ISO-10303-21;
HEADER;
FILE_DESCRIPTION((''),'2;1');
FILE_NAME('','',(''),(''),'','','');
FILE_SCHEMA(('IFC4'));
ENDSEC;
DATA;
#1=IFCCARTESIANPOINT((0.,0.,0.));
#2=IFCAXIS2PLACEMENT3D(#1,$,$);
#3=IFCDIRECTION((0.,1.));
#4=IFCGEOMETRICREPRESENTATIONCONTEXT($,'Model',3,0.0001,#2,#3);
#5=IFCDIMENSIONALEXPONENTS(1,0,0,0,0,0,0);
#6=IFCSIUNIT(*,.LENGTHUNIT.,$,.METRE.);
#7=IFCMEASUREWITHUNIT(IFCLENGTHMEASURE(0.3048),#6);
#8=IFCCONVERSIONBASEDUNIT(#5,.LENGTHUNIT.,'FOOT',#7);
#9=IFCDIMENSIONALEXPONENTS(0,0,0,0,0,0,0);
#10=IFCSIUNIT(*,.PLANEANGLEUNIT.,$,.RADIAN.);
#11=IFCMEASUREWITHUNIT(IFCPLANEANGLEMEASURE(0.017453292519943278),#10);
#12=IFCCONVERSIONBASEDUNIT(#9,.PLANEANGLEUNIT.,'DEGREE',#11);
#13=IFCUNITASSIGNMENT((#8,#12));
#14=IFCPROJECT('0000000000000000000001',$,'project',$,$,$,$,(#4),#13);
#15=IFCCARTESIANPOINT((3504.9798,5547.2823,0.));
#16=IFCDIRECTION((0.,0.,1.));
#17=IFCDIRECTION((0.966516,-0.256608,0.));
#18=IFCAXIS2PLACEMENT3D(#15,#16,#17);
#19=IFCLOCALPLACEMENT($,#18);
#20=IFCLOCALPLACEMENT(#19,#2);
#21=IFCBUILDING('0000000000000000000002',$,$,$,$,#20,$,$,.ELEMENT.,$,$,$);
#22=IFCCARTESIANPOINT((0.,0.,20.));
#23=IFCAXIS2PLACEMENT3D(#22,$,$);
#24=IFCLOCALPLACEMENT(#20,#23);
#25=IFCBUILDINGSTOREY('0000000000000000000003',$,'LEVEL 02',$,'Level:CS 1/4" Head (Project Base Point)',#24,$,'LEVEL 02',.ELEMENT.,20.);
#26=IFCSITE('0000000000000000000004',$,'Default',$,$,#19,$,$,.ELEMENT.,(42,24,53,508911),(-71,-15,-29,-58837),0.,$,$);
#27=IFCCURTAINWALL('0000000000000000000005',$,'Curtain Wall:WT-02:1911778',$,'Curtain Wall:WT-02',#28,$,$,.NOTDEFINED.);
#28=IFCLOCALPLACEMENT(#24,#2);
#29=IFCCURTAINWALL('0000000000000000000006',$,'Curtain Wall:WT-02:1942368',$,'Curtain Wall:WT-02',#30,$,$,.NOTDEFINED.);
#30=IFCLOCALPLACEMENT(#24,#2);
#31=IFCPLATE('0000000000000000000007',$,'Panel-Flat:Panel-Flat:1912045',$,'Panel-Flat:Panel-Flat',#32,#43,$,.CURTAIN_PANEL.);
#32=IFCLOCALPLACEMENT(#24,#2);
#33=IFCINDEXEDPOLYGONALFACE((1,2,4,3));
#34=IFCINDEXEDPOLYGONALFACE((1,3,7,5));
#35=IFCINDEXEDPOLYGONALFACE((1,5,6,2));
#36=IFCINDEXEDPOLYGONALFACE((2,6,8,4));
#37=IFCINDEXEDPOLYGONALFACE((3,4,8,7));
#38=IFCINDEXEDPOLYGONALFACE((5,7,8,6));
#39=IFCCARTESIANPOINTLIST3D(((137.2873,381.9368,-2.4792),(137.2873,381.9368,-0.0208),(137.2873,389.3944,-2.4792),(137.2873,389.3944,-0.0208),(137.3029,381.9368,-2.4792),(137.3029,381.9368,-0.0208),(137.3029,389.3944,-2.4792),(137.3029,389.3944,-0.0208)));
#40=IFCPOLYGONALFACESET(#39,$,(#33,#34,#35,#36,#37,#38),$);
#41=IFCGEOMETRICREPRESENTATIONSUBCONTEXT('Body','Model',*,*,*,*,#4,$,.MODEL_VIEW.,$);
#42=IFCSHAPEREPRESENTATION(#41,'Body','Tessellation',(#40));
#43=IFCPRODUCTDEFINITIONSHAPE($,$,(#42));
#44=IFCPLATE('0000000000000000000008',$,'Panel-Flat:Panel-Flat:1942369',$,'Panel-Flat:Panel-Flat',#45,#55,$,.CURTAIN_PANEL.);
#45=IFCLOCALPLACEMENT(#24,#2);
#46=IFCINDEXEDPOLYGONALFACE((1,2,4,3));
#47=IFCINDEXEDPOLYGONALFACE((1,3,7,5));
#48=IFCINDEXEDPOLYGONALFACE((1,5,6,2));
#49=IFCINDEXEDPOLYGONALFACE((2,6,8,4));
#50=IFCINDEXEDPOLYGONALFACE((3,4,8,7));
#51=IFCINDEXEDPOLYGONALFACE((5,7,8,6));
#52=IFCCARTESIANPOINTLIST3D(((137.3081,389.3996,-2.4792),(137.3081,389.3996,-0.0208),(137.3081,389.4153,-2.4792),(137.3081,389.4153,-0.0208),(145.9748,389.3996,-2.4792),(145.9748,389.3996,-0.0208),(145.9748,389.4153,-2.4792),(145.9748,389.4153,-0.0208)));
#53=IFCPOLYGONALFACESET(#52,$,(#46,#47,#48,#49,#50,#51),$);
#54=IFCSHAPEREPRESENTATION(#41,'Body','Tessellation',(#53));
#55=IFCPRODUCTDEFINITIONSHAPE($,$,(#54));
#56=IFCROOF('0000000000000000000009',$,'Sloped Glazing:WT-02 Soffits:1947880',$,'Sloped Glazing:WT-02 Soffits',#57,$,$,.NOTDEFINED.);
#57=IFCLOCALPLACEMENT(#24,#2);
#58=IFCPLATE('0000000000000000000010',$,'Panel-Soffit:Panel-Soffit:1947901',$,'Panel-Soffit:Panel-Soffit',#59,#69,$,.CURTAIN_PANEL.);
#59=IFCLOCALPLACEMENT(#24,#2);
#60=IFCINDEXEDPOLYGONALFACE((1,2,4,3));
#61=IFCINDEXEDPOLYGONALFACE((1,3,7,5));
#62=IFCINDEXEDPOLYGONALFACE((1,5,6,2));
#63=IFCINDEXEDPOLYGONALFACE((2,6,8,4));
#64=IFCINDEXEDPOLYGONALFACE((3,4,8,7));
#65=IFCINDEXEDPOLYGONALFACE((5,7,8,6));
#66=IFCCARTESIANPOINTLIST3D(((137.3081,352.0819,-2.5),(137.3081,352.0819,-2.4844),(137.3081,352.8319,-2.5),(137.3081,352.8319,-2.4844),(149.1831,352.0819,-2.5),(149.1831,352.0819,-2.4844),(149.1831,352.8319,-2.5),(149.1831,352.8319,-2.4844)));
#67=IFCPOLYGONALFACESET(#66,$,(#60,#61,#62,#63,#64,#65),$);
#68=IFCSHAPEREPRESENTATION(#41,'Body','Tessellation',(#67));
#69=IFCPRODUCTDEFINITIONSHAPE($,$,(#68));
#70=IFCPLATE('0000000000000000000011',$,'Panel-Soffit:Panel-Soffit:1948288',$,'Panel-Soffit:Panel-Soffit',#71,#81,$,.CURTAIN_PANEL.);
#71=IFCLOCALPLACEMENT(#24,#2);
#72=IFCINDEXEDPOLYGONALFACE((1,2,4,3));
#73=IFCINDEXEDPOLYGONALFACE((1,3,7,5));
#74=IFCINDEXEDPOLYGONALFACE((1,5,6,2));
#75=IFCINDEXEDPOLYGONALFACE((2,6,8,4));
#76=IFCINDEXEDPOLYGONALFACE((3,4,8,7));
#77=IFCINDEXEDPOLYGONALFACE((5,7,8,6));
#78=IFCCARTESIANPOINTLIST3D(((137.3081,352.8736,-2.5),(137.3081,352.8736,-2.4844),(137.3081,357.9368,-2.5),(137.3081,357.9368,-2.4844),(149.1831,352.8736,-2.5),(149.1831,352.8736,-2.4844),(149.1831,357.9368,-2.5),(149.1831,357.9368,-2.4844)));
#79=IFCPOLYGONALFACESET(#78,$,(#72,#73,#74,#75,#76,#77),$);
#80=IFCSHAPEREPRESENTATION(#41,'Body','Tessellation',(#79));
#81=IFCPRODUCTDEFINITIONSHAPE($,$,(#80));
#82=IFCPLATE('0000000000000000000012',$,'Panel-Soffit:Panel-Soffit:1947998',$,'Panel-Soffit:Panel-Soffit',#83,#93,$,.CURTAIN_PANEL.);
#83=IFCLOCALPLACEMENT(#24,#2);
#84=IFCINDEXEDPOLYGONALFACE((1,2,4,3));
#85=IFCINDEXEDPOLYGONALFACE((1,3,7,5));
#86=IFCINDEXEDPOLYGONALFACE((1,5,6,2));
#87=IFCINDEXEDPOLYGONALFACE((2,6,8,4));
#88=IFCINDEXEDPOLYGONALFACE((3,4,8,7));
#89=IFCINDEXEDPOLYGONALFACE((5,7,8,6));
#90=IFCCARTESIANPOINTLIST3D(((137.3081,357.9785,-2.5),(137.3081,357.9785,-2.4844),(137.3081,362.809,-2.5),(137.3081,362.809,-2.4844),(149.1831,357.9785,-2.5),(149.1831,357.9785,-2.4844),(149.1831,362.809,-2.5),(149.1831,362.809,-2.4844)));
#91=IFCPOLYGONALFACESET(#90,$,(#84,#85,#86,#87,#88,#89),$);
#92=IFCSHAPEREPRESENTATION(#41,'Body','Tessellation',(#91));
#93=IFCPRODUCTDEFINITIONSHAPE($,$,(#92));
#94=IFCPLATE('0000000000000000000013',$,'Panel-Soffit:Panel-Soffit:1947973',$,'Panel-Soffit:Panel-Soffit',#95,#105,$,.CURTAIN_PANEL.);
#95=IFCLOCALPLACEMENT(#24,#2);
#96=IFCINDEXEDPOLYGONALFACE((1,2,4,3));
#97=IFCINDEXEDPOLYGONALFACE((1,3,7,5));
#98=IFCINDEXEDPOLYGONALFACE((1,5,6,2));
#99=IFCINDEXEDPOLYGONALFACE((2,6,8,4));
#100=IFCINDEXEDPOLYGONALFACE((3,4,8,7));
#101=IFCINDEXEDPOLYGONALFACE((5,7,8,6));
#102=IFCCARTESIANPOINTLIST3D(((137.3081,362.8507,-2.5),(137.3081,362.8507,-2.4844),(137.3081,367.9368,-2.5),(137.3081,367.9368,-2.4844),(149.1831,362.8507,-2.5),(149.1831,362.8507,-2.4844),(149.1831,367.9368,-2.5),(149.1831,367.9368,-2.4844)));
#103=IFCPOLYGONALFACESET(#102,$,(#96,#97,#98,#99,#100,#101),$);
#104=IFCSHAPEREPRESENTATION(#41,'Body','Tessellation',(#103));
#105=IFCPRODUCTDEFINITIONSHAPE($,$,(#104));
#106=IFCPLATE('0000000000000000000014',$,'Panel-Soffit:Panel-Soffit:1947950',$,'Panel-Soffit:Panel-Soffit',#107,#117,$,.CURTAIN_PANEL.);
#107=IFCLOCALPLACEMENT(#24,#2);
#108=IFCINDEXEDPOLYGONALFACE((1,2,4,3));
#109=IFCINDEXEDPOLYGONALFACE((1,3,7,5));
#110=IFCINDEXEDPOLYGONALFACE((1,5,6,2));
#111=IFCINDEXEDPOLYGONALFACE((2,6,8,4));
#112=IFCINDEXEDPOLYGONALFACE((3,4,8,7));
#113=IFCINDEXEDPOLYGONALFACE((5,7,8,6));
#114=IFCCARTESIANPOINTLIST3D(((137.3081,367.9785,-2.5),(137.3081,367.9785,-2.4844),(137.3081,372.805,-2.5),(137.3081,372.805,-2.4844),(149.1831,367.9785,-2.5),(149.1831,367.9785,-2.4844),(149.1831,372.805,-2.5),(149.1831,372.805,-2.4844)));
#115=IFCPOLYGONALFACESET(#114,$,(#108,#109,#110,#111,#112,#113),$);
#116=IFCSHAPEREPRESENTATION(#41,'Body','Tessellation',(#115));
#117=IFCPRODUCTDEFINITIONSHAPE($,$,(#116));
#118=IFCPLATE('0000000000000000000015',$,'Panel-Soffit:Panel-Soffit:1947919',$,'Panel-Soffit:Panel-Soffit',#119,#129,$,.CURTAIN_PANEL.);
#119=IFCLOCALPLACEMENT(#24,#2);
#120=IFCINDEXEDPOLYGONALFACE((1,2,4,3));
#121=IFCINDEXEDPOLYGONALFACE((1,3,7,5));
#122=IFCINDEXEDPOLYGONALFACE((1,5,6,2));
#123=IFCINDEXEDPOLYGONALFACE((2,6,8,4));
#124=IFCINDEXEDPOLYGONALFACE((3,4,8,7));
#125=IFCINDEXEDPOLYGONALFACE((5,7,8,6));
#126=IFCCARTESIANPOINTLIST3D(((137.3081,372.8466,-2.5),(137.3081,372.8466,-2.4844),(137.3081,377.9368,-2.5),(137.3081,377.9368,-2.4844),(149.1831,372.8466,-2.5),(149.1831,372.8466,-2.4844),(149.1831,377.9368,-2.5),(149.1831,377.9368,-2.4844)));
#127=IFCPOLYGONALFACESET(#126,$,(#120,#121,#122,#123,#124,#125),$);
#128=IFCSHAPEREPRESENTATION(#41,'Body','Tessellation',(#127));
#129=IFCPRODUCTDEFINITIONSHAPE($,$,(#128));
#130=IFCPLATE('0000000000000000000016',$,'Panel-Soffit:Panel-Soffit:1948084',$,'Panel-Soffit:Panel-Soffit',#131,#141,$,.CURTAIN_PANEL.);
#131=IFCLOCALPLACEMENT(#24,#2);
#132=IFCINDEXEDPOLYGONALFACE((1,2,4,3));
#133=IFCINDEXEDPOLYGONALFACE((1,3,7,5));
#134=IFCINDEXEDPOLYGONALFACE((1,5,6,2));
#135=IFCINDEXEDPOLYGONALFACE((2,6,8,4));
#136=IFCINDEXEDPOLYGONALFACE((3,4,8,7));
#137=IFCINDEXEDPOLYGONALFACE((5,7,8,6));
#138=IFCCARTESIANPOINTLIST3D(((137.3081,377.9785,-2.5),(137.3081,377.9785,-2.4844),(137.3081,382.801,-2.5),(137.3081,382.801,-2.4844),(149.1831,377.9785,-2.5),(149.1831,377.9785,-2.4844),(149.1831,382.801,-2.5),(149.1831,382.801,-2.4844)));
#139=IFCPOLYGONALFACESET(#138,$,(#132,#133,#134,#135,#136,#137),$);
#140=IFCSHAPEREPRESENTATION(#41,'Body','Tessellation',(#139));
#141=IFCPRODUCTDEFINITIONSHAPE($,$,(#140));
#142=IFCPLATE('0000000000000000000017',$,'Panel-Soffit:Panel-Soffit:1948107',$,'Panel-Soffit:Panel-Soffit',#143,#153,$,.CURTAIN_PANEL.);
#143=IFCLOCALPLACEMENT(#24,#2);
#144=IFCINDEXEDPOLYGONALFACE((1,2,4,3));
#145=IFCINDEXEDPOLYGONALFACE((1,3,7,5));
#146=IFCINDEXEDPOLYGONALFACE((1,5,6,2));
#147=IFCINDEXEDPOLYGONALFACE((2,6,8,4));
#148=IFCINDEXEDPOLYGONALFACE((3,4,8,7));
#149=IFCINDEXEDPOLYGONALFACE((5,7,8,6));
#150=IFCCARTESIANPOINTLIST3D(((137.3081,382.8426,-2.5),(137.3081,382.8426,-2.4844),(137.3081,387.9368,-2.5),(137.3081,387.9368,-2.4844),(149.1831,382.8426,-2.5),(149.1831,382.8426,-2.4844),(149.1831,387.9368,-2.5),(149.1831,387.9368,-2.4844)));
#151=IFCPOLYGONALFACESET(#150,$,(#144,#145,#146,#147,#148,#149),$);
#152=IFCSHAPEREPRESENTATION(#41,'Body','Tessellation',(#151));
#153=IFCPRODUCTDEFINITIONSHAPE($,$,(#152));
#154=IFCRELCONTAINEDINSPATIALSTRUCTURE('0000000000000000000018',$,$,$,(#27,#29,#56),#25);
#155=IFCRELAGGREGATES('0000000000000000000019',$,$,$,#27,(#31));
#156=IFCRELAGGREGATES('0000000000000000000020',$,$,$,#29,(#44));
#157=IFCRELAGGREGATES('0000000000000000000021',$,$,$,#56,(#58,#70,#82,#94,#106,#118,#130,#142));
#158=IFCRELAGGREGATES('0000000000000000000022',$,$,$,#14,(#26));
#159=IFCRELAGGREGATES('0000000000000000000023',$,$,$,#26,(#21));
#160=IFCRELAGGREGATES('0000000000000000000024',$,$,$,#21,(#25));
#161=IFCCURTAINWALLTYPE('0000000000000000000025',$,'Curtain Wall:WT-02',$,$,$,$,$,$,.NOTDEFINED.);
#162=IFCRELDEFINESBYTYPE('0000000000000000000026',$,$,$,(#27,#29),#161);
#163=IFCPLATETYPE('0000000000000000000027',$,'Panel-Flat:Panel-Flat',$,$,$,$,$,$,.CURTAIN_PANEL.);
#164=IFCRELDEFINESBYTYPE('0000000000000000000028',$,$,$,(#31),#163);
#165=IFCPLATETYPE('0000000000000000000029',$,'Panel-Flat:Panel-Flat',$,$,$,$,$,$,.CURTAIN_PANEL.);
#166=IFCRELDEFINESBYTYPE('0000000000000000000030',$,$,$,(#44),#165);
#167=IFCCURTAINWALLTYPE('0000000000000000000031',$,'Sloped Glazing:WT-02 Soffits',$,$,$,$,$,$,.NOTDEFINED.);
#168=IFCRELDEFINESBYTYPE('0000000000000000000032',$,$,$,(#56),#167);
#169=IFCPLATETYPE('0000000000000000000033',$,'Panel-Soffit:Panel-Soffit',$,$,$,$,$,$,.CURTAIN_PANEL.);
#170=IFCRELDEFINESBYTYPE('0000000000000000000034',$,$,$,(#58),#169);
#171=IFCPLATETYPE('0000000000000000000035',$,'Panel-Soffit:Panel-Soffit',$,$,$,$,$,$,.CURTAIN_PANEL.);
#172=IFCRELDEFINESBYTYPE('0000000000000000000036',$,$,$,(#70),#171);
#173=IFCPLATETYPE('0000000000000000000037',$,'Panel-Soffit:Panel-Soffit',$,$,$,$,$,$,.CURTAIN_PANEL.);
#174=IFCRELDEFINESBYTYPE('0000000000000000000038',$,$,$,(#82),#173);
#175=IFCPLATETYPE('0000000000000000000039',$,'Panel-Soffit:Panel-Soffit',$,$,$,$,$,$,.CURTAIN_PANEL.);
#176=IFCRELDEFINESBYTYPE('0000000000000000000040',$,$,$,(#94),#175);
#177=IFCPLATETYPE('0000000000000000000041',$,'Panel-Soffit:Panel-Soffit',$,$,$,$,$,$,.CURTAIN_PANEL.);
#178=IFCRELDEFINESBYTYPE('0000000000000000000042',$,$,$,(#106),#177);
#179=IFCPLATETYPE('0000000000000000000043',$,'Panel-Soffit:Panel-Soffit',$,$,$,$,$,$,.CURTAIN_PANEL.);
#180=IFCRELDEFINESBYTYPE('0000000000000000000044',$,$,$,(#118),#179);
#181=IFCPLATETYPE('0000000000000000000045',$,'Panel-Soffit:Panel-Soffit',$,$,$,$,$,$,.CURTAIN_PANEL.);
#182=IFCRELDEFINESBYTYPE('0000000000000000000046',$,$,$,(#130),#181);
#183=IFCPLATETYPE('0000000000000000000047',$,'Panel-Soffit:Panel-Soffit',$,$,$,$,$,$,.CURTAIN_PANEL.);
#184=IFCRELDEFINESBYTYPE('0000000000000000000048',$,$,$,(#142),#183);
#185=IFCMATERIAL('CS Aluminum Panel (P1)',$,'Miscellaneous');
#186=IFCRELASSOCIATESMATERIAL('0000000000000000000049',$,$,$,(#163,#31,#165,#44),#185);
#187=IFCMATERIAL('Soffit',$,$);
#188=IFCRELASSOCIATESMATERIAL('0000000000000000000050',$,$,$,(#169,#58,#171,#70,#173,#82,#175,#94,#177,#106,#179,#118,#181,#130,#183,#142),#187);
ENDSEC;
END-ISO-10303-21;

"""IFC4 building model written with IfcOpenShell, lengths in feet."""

from ifc_helpers import new_model, entity, si_unit, converted_unit, direction, frame, origin, place, context, subcontext, project, spatial, indexed_curve, outline, extrude, source, transform, mapped, material, type_object, type_shapes, element, aggregate, save


model = new_model("IFC4")

# Units and contexts
model_context = context("Model", 3, precision=0.0001, world=origin(), true_north=direction((0.0, 1.0)))
body_context = subcontext(model_context, "Body", "Model", "MODEL_VIEW")
ifc_project = project(units=[converted_unit("LENGTHUNIT", "FOOT", entity("IfcLengthMeasure", 0.3048), si_unit("LENGTHUNIT", "METRE"), dimensions=[1, 0, 0, 0, 0, 0, 0]), converted_unit("PLANEANGLEUNIT", "DEGREE", entity("IfcPlaneAngleMeasure", 0.017453292519943278), si_unit("PLANEANGLEUNIT", "RADIAN"), dimensions=[0, 0, 0, 0, 0, 0, 0])], contexts=[model_context])

# Site, building, storey
site_placement = place(None, frame((3504.9798, 5547.2823, 0.0), z_axis=(0.0, 0.0, 1.0), x_axis=(0.966516, -0.256608, 0.0)))
site = spatial("IfcSite", under=ifc_project, at=site_placement, Name="Default", CompositionType="ELEMENT", RefLatitude=(42, 24, 53, 508911), RefLongitude=(-71, -15, -29, -58837), RefElevation=0.0)
building_placement = place(site_placement, origin())
building = spatial("IfcBuilding", under=site, at=building_placement, CompositionType="ELEMENT")
storey_placement = place(building_placement, frame((0.0, 0.0, 20.0)))
storey = spatial("IfcBuildingStorey", under=building, at=storey_placement, Name="LEVEL 02", ObjectType="Level:CS 1/4\" Head (Project Base Point)", LongName="LEVEL 02", CompositionType="ELEMENT", Elevation=20.0)

# Curtain walls
curtain_wall_type_1 = type_object("IfcCurtainWallType", Name="Curtain Wall:WT-02", PredefinedType="NOTDEFINED")
curtain_wall_1_placement = place(storey_placement, frame((0.0, 0.0, -20.0)))
curtain_wall_1 = element("IfcCurtainWall", 1, at=curtain_wall_1_placement, inside=storey, type_object=curtain_wall_type_1, Name="Curtain Wall:WT-02:1911778", ObjectType="Curtain Wall:WT-02", PredefinedType="NOTDEFINED")
ifc_material_1 = material(Name="CS Aluminum Panel (P1)", Category="Miscellaneous")
curtain_wall_2_placement = place(storey_placement, frame((0.0, 0.0, -20.0)))
curtain_wall_2 = element("IfcCurtainWall", 2, at=curtain_wall_2_placement, inside=storey, type_object=curtain_wall_type_1, Name="Curtain Wall:WT-02:1942368", ObjectType="Curtain Wall:WT-02", PredefinedType="NOTDEFINED")

# Plates
plate_type_1 = type_object("IfcPlateType", Name="Panel-Flat:Panel-Flat", PredefinedType="CURTAIN_PANEL", material=ifc_material_1)
shared_shape_1 = source(origin(), body_context, "Body", "SweptSolid", [
    extrude(outline(indexed_curve([(-0.0078, -3.7288), (0.0078, -3.7288), (0.0078, 3.7288), (-0.0078, 3.7288), (-0.0078, -3.7288)], self_intersect=False)), frame((3.7288, 0.0078, 0.0), z_axis=(0.0, 0.0, 1.0), x_axis=(0.0, -1.0, 0.0)), (0.0, 0.0, 1.0), 2.4583),
])
type_shapes(plate_type_1, [shared_shape_1])
plate_1_placement = place(curtain_wall_1_placement, frame((137.3029, 381.9368, 17.5208), z_axis=(0.0, 0.0, 1.0), x_axis=(0.0, 1.0, 0.0)))
plate_1 = element("IfcPlate", 3, at=plate_1_placement, type_object=plate_type_1, material=ifc_material_1, Name="Panel-Flat:Panel-Flat:1912045", ObjectType="Panel-Flat:Panel-Flat", PredefinedType="CURTAIN_PANEL", context=body_context, shape_type="MappedRepresentation", body=[
    mapped(shared_shape_1, transform((0.0, 0.0, 0.0), scale=1.0)),
])
aggregate(curtain_wall_1, [plate_1])
plate_type_2 = type_object("IfcPlateType", Name="Panel-Flat:Panel-Flat", PredefinedType="CURTAIN_PANEL", material=ifc_material_1)
shared_shape_2 = source(origin(), body_context, "Body", "SweptSolid", [
    extrude(outline(indexed_curve([(-0.0078, -4.3333), (0.0078, -4.3333), (0.0078, 4.3333), (-0.0078, 4.3333), (-0.0078, -4.3333)], self_intersect=False)), frame((4.3333, 0.0078, 0.0), z_axis=(0.0, 0.0, 1.0), x_axis=(0.0, -1.0, 0.0)), (0.0, 0.0, 1.0), 2.4583),
])
type_shapes(plate_type_2, [shared_shape_2])
plate_2_placement = place(curtain_wall_2_placement, frame((137.3081, 389.3996, 17.5208)))
plate_2 = element("IfcPlate", 4, at=plate_2_placement, type_object=plate_type_2, material=ifc_material_1, Name="Panel-Flat:Panel-Flat:1942369", ObjectType="Panel-Flat:Panel-Flat", PredefinedType="CURTAIN_PANEL", context=body_context, shape_type="MappedRepresentation", body=[
    mapped(shared_shape_2, transform((0.0, 0.0, 0.0), scale=1.0)),
])
aggregate(curtain_wall_2, [plate_2])

# Roof, plates
curtain_wall_type_2 = type_object("IfcCurtainWallType", Name="Sloped Glazing:WT-02 Soffits", PredefinedType="NOTDEFINED")
roof_1_placement = place(storey_placement, frame((0.0, 0.0, -20.0)))
roof_1 = element("IfcRoof", 5, at=roof_1_placement, inside=storey, type_object=curtain_wall_type_2, Name="Sloped Glazing:WT-02 Soffits:1947880", ObjectType="Sloped Glazing:WT-02 Soffits", PredefinedType="NOTDEFINED")
ifc_material_2 = material(Name="Soffit")
plate_type_3 = type_object("IfcPlateType", Name="Panel-Soffit:Panel-Soffit", PredefinedType="CURTAIN_PANEL", material=ifc_material_2)
shared_shape_3 = source(origin(), body_context, "Body", "SweptSolid", [
    extrude(outline(indexed_curve([(-0.0078, -5.9375), (0.0078, -5.9375), (0.0078, 5.9375), (-0.0078, 5.9375), (-0.0078, -5.9375)], self_intersect=False)), frame((5.9375, 0.0078, 0.0), z_axis=(0.0, 0.0, 1.0), x_axis=(0.0, -1.0, 0.0)), (0.0, 0.0, 1.0), 0.75),
])
type_shapes(plate_type_3, [shared_shape_3])
plate_3_placement = place(roof_1_placement, frame((137.3081, 352.0819, 17.5156), z_axis=(0.0, 1.0, 0.0), x_axis=(1.0, 0.0, 0.0)))
plate_3 = element("IfcPlate", 6, at=plate_3_placement, type_object=plate_type_3, material=ifc_material_2, Name="Panel-Soffit:Panel-Soffit:1947901", ObjectType="Panel-Soffit:Panel-Soffit", PredefinedType="CURTAIN_PANEL", context=body_context, shape_type="MappedRepresentation", body=[
    mapped(shared_shape_3, transform((0.0, 0.0, 0.0), scale=1.0)),
])
plate_type_4 = type_object("IfcPlateType", Name="Panel-Soffit:Panel-Soffit", PredefinedType="CURTAIN_PANEL", material=ifc_material_2)
shared_shape_4 = source(origin(), body_context, "Body", "SweptSolid", [
    extrude(outline(indexed_curve([(-0.0078, -5.9375), (0.0078, -5.9375), (0.0078, 5.9375), (-0.0078, 5.9375), (-0.0078, -5.9375)], self_intersect=False)), frame((5.9375, 0.0078, 0.0), z_axis=(0.0, 0.0, 1.0), x_axis=(0.0, -1.0, 0.0)), (0.0, 0.0, 1.0), 5.0633),
])
type_shapes(plate_type_4, [shared_shape_4])
plate_4_placement = place(roof_1_placement, frame((137.3081, 352.8736, 17.5156), z_axis=(0.0, 1.0, 0.0), x_axis=(1.0, 0.0, 0.0)))
plate_4 = element("IfcPlate", 7, at=plate_4_placement, type_object=plate_type_4, material=ifc_material_2, Name="Panel-Soffit:Panel-Soffit:1948288", ObjectType="Panel-Soffit:Panel-Soffit", PredefinedType="CURTAIN_PANEL", context=body_context, shape_type="MappedRepresentation", body=[
    mapped(shared_shape_4, transform((0.0, 0.0, 0.0), scale=1.0)),
])
plate_type_5 = type_object("IfcPlateType", Name="Panel-Soffit:Panel-Soffit", PredefinedType="CURTAIN_PANEL", material=ifc_material_2)
shared_shape_5 = source(origin(), body_context, "Body", "SweptSolid", [
    extrude(outline(indexed_curve([(-0.0078, -5.9375), (0.0078, -5.9375), (0.0078, 5.9375), (-0.0078, 5.9375), (-0.0078, -5.9375)], self_intersect=False)), frame((5.9375, 0.0078, 0.0), z_axis=(0.0, 0.0, 1.0), x_axis=(0.0, -1.0, 0.0)), (0.0, 0.0, 1.0), 4.8305),
])
type_shapes(plate_type_5, [shared_shape_5])
plate_5_placement = place(roof_1_placement, frame((137.3081, 357.9785, 17.5156), z_axis=(0.0, 1.0, 0.0), x_axis=(1.0, 0.0, 0.0)))
plate_5 = element("IfcPlate", 8, at=plate_5_placement, type_object=plate_type_5, material=ifc_material_2, Name="Panel-Soffit:Panel-Soffit:1947998", ObjectType="Panel-Soffit:Panel-Soffit", PredefinedType="CURTAIN_PANEL", context=body_context, shape_type="MappedRepresentation", body=[
    mapped(shared_shape_5, transform((0.0, 0.0, 0.0), scale=1.0)),
])
plate_type_6 = type_object("IfcPlateType", Name="Panel-Soffit:Panel-Soffit", PredefinedType="CURTAIN_PANEL", material=ifc_material_2)
shared_shape_6 = source(origin(), body_context, "Body", "SweptSolid", [
    extrude(outline(indexed_curve([(-0.0078, -5.9375), (0.0078, -5.9375), (0.0078, 5.9375), (-0.0078, 5.9375), (-0.0078, -5.9375)], self_intersect=False)), frame((5.9375, 0.0078, 0.0), z_axis=(0.0, 0.0, 1.0), x_axis=(0.0, -1.0, 0.0)), (0.0, 0.0, 1.0), 5.0862),
])
type_shapes(plate_type_6, [shared_shape_6])
plate_6_placement = place(roof_1_placement, frame((137.3081, 362.8507, 17.5156), z_axis=(0.0, 1.0, 0.0), x_axis=(1.0, 0.0, 0.0)))
plate_6 = element("IfcPlate", 9, at=plate_6_placement, type_object=plate_type_6, material=ifc_material_2, Name="Panel-Soffit:Panel-Soffit:1947973", ObjectType="Panel-Soffit:Panel-Soffit", PredefinedType="CURTAIN_PANEL", context=body_context, shape_type="MappedRepresentation", body=[
    mapped(shared_shape_6, transform((0.0, 0.0, 0.0), scale=1.0)),
])
plate_type_7 = type_object("IfcPlateType", Name="Panel-Soffit:Panel-Soffit", PredefinedType="CURTAIN_PANEL", material=ifc_material_2)
shared_shape_7 = source(origin(), body_context, "Body", "SweptSolid", [
    extrude(outline(indexed_curve([(-0.0078, -5.9375), (0.0078, -5.9375), (0.0078, 5.9375), (-0.0078, 5.9375), (-0.0078, -5.9375)], self_intersect=False)), frame((5.9375, 0.0078, 0.0), z_axis=(0.0, 0.0, 1.0), x_axis=(0.0, -1.0, 0.0)), (0.0, 0.0, 1.0), 4.8265),
])
type_shapes(plate_type_7, [shared_shape_7])
plate_7_placement = place(roof_1_placement, frame((137.3081, 367.9785, 17.5156), z_axis=(0.0, 1.0, 0.0), x_axis=(1.0, 0.0, 0.0)))
plate_7 = element("IfcPlate", 10, at=plate_7_placement, type_object=plate_type_7, material=ifc_material_2, Name="Panel-Soffit:Panel-Soffit:1947950", ObjectType="Panel-Soffit:Panel-Soffit", PredefinedType="CURTAIN_PANEL", context=body_context, shape_type="MappedRepresentation", body=[
    mapped(shared_shape_7, transform((0.0, 0.0, 0.0), scale=1.0)),
])
plate_type_8 = type_object("IfcPlateType", Name="Panel-Soffit:Panel-Soffit", PredefinedType="CURTAIN_PANEL", material=ifc_material_2)
shared_shape_8 = source(origin(), body_context, "Body", "SweptSolid", [
    extrude(outline(indexed_curve([(-0.0078, -5.9375), (0.0078, -5.9375), (0.0078, 5.9375), (-0.0078, 5.9375), (-0.0078, -5.9375)], self_intersect=False)), frame((5.9375, 0.0078, 0.0), z_axis=(0.0, 0.0, 1.0), x_axis=(0.0, -1.0, 0.0)), (0.0, 0.0, 1.0), 5.0902),
])
type_shapes(plate_type_8, [shared_shape_8])
plate_8_placement = place(roof_1_placement, frame((137.3081, 372.8466, 17.5156), z_axis=(0.0, 1.0, 0.0), x_axis=(1.0, 0.0, 0.0)))
plate_8 = element("IfcPlate", 11, at=plate_8_placement, type_object=plate_type_8, material=ifc_material_2, Name="Panel-Soffit:Panel-Soffit:1947919", ObjectType="Panel-Soffit:Panel-Soffit", PredefinedType="CURTAIN_PANEL", context=body_context, shape_type="MappedRepresentation", body=[
    mapped(shared_shape_8, transform((0.0, 0.0, 0.0), scale=1.0)),
])
plate_type_9 = type_object("IfcPlateType", Name="Panel-Soffit:Panel-Soffit", PredefinedType="CURTAIN_PANEL", material=ifc_material_2)
shared_shape_9 = source(origin(), body_context, "Body", "SweptSolid", [
    extrude(outline(indexed_curve([(-0.0078, -5.9375), (0.0078, -5.9375), (0.0078, 5.9375), (-0.0078, 5.9375), (-0.0078, -5.9375)], self_intersect=False)), frame((5.9375, 0.0078, 0.0), z_axis=(0.0, 0.0, 1.0), x_axis=(0.0, -1.0, 0.0)), (0.0, 0.0, 1.0), 4.8224),
])
type_shapes(plate_type_9, [shared_shape_9])
plate_9_placement = place(roof_1_placement, frame((137.3081, 377.9785, 17.5156), z_axis=(0.0, 1.0, 0.0), x_axis=(1.0, 0.0, 0.0)))
plate_9 = element("IfcPlate", 12, at=plate_9_placement, type_object=plate_type_9, material=ifc_material_2, Name="Panel-Soffit:Panel-Soffit:1948084", ObjectType="Panel-Soffit:Panel-Soffit", PredefinedType="CURTAIN_PANEL", context=body_context, shape_type="MappedRepresentation", body=[
    mapped(shared_shape_9, transform((0.0, 0.0, 0.0), scale=1.0)),
])
plate_type_10 = type_object("IfcPlateType", Name="Panel-Soffit:Panel-Soffit", PredefinedType="CURTAIN_PANEL", material=ifc_material_2)
shared_shape_10 = source(origin(), body_context, "Body", "SweptSolid", [
    extrude(outline(indexed_curve([(-0.0078, -5.9375), (0.0078, -5.9375), (0.0078, 5.9375), (-0.0078, 5.9375), (-0.0078, -5.9375)], self_intersect=False)), frame((5.9375, 0.0078, 0.0), z_axis=(0.0, 0.0, 1.0), x_axis=(0.0, -1.0, 0.0)), (0.0, 0.0, 1.0), 5.0942),
])
type_shapes(plate_type_10, [shared_shape_10])
plate_10_placement = place(roof_1_placement, frame((137.3081, 382.8426, 17.5156), z_axis=(0.0, 1.0, 0.0), x_axis=(1.0, 0.0, 0.0)))
plate_10 = element("IfcPlate", 13, at=plate_10_placement, type_object=plate_type_10, material=ifc_material_2, Name="Panel-Soffit:Panel-Soffit:1948107", ObjectType="Panel-Soffit:Panel-Soffit", PredefinedType="CURTAIN_PANEL", context=body_context, shape_type="MappedRepresentation", body=[
    mapped(shared_shape_10, transform((0.0, 0.0, 0.0), scale=1.0)),
])
aggregate(roof_1, [plate_3, plate_4, plate_5, plate_6, plate_7, plate_8, plate_9, plate_10])

save(model, "model.ifc")
